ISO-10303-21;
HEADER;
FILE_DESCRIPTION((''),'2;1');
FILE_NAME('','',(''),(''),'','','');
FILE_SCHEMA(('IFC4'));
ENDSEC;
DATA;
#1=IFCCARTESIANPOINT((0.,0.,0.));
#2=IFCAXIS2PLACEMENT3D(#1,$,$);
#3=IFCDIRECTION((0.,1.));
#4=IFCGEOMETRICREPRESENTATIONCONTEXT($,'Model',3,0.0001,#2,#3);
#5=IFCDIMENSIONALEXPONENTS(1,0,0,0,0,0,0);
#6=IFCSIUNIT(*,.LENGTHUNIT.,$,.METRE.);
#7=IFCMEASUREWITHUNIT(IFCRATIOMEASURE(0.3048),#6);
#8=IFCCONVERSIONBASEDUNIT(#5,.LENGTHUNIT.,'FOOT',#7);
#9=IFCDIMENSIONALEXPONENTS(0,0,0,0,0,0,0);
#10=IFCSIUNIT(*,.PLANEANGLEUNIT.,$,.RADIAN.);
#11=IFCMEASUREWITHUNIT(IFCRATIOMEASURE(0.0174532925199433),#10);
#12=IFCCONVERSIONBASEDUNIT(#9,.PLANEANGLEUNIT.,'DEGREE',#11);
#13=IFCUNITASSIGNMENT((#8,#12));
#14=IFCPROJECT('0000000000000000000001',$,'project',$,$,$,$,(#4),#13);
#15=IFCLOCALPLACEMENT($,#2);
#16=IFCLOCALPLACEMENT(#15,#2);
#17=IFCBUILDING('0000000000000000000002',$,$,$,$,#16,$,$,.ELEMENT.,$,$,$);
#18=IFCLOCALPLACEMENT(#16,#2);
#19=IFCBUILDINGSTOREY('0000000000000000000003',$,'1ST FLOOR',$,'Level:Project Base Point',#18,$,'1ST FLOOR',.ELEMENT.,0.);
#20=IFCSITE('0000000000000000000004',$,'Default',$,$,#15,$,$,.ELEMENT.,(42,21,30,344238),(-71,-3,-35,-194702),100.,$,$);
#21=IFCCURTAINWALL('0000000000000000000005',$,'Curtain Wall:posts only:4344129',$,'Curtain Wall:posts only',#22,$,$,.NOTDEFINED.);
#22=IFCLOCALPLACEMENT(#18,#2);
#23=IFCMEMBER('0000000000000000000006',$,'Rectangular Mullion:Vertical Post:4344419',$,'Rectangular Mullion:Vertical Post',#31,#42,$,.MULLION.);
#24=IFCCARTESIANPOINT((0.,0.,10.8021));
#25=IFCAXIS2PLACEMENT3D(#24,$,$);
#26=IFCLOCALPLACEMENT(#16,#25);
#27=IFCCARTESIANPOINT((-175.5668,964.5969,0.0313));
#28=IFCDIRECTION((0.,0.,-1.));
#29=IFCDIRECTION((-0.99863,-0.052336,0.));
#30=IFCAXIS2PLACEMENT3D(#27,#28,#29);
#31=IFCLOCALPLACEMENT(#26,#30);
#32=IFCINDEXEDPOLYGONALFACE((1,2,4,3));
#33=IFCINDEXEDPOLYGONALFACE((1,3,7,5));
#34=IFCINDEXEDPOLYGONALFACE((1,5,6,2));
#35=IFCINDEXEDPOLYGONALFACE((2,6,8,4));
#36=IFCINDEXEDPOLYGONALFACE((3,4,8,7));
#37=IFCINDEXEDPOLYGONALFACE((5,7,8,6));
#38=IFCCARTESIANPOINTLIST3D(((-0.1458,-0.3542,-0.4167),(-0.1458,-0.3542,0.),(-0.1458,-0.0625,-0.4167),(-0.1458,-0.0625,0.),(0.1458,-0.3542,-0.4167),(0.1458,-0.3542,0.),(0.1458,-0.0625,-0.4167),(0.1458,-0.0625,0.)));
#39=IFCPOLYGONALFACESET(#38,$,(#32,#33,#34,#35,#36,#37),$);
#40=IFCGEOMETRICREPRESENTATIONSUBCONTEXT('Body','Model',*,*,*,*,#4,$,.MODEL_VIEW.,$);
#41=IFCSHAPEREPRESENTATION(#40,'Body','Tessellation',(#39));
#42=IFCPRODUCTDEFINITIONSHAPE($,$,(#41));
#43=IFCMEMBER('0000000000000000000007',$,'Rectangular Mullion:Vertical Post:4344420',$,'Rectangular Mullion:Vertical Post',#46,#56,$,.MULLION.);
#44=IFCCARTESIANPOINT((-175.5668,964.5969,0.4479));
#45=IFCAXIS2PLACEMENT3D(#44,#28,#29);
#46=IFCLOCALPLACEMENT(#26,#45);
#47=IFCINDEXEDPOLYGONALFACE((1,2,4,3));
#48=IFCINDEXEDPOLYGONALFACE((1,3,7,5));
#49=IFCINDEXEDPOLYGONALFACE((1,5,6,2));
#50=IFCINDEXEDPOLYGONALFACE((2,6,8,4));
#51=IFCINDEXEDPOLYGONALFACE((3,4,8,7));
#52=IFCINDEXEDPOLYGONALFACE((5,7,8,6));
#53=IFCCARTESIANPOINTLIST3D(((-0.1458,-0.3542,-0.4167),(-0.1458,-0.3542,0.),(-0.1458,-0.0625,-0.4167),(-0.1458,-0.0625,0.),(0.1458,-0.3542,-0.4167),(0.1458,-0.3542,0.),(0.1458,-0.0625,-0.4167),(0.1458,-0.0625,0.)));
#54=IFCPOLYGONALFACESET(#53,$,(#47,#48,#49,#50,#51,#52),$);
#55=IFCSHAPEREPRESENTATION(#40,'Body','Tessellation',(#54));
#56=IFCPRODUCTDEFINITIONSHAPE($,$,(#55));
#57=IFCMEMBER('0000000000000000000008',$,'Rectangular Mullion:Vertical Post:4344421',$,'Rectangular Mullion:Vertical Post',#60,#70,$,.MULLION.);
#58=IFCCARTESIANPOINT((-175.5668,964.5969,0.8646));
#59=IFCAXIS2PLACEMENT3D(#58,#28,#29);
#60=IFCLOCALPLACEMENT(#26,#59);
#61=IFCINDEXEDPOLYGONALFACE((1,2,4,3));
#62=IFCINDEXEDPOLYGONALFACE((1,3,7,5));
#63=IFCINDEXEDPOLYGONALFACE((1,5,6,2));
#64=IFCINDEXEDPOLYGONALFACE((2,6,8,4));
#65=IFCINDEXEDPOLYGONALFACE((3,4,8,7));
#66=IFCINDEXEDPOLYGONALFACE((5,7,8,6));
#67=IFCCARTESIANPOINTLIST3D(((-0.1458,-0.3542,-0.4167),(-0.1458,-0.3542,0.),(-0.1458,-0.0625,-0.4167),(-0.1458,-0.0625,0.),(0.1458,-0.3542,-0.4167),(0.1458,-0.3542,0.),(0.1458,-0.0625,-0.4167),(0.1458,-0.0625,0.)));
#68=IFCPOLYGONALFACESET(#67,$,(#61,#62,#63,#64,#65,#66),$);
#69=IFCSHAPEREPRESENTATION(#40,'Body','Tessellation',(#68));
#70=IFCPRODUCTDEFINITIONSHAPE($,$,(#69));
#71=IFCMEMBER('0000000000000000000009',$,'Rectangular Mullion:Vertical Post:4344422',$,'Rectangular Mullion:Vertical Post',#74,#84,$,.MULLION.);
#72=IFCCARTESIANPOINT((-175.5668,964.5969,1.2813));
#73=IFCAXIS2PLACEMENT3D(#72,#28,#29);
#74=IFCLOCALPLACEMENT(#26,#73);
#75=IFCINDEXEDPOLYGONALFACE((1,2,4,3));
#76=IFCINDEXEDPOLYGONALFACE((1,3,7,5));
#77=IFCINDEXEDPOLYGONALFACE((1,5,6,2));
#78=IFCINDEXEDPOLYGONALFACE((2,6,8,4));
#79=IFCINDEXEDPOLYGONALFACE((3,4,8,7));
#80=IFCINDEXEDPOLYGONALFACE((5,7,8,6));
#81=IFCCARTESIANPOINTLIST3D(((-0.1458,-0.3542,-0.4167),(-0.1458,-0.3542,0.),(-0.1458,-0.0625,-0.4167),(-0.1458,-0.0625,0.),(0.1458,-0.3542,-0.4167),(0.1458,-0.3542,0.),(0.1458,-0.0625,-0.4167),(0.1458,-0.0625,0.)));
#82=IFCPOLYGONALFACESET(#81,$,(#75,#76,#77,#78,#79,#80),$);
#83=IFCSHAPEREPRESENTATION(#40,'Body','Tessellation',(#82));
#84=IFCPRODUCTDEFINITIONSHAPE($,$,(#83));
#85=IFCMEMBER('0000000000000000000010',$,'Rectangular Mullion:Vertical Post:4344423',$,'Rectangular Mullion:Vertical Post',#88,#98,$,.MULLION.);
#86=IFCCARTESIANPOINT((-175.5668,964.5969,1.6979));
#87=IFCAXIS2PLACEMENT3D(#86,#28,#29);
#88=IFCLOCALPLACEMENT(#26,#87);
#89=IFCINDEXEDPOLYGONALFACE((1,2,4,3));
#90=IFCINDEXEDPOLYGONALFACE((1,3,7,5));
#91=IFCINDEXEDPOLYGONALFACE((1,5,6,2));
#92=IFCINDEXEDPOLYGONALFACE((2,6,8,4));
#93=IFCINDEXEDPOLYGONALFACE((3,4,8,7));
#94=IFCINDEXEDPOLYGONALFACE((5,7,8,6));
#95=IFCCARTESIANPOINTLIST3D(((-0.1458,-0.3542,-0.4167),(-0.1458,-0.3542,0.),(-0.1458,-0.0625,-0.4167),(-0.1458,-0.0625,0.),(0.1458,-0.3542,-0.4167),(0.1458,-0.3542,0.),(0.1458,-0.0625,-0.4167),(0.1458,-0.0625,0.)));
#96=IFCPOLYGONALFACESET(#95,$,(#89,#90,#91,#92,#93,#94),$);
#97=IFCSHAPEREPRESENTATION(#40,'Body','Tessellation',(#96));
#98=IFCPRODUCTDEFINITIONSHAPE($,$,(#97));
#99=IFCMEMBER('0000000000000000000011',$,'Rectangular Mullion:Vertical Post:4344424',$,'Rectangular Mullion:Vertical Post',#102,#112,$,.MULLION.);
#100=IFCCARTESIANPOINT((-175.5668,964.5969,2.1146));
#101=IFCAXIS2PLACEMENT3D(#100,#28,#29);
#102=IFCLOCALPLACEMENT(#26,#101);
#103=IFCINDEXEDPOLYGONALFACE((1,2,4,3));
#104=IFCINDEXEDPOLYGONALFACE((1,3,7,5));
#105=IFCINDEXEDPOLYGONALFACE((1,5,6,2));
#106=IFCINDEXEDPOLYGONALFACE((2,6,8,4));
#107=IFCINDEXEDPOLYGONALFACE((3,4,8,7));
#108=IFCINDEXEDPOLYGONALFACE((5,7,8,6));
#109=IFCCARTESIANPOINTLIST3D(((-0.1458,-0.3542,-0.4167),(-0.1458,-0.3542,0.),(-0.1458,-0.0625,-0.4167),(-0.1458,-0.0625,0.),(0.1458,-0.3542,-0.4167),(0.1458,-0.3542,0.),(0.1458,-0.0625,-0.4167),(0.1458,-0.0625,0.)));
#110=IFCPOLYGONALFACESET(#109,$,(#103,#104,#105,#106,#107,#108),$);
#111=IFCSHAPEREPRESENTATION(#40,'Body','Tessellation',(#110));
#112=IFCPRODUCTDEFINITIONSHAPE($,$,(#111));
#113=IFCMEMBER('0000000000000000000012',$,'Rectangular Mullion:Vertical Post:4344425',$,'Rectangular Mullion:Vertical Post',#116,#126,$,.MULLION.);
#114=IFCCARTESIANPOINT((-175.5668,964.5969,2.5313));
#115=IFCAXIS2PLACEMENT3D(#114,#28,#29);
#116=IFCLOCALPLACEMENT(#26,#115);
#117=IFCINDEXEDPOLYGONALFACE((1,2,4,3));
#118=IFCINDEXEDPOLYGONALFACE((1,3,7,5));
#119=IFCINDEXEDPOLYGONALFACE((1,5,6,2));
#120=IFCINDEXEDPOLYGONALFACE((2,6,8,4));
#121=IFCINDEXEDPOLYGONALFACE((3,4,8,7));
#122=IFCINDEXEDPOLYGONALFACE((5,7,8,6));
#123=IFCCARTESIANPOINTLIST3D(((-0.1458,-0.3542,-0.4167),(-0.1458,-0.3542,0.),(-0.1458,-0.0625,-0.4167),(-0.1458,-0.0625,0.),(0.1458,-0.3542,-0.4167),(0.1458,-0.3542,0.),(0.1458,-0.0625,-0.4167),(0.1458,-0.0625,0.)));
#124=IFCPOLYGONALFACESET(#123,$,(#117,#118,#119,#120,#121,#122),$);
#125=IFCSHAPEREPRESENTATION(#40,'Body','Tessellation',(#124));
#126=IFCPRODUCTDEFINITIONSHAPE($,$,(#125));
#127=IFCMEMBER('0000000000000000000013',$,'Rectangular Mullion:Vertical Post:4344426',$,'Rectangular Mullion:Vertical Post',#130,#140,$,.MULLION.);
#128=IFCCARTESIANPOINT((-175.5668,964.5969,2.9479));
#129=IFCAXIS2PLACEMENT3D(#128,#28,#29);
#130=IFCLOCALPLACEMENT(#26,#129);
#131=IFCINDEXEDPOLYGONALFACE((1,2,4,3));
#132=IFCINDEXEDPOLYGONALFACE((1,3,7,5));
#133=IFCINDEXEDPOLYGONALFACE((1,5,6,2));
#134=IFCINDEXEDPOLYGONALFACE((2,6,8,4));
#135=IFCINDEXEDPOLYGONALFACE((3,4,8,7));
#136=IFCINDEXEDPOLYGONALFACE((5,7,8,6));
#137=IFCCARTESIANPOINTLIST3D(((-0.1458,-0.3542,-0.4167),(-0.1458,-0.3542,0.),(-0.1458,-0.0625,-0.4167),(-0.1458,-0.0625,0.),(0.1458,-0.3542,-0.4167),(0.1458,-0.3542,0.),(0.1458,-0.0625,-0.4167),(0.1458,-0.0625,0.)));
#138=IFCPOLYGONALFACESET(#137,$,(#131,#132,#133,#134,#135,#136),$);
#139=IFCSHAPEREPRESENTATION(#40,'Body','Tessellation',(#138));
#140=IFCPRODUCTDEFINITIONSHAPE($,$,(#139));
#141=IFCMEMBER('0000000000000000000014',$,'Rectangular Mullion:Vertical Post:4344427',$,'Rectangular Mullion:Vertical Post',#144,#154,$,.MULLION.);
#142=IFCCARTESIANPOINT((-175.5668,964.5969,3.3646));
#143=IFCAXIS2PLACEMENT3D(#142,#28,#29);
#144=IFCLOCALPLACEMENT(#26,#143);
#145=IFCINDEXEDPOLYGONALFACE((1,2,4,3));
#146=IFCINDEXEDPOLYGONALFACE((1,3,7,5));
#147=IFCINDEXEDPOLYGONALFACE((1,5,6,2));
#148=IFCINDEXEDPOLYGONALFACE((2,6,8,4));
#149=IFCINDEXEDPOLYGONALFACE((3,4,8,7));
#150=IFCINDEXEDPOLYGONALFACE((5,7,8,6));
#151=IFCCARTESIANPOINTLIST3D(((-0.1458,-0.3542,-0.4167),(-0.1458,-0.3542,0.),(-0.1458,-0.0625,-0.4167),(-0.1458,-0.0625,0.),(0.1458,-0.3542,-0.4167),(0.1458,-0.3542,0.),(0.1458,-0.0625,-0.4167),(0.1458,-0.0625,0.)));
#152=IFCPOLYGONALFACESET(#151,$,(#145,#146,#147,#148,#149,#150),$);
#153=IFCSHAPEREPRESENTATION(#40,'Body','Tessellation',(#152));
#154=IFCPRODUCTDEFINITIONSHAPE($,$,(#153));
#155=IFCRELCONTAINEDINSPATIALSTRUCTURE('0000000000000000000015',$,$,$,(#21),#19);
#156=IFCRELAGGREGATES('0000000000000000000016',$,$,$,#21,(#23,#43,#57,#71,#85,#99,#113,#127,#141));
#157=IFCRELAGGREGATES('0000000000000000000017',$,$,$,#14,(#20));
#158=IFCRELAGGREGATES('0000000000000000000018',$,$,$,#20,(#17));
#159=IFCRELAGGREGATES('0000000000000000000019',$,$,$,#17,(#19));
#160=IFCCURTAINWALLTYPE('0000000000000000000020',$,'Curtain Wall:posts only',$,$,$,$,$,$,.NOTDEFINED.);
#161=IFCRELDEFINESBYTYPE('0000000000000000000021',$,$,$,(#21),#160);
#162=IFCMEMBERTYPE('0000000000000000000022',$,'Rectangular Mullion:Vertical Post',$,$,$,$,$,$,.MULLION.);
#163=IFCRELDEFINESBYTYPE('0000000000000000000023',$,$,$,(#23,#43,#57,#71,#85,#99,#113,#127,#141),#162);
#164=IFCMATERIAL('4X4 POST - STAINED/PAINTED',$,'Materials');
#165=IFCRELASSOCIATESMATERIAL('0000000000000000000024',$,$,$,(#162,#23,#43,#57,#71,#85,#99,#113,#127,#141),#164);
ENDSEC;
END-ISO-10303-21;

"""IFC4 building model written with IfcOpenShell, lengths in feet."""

from ifc_helpers import new_model, entity, si_unit, converted_unit, direction, frame, origin, origin_2d_with_axis, place, context, subcontext, project, spatial, rectangle, extrude, source, transform, mapped, material, material_profile, profile_set, profile_usage, type_object, type_shapes, element, aggregate, save


model = new_model("IFC4")

# Units and contexts
model_context = context("Model", 3, precision=0.0001, world=origin(), true_north=direction((0.0, 1.0)))
body_context = subcontext(model_context, "Body", "Model", "MODEL_VIEW")
ifc_project = project(units=[converted_unit("LENGTHUNIT", "FOOT", entity("IfcRatioMeasure", 0.3048), si_unit("LENGTHUNIT", "METRE"), dimensions=[1, 0, 0, 0, 0, 0, 0]), converted_unit("PLANEANGLEUNIT", "DEGREE", entity("IfcRatioMeasure", 0.0174532925199433), si_unit("PLANEANGLEUNIT", "RADIAN"), dimensions=[0, 0, 0, 0, 0, 0, 0])], contexts=[model_context])

# Site, building, storey
site_placement = place(None, origin())
site = spatial("IfcSite", under=ifc_project, at=site_placement, Name="Default", CompositionType="ELEMENT", RefLatitude=(42, 21, 30, 344238), RefLongitude=(-71, -3, -35, -194702), RefElevation=100.0)
building_placement = place(site_placement, origin())
building = spatial("IfcBuilding", under=site, at=building_placement, CompositionType="ELEMENT")
storey_placement = place(building_placement, origin())
storey = spatial("IfcBuildingStorey", under=building, at=storey_placement, Name="1ST FLOOR", ObjectType="Level:Project Base Point", LongName="1ST FLOOR", CompositionType="ELEMENT", Elevation=0.0)

# Curtain wall, members
curtain_wall_type_1 = type_object("IfcCurtainWallType", Name="Curtain Wall:posts only", PredefinedType="NOTDEFINED")
curtain_wall_1_placement = place(storey_placement, origin())
curtain_wall_1 = element("IfcCurtainWall", 1, at=curtain_wall_1_placement, inside=storey, type_object=curtain_wall_type_1, Name="Curtain Wall:posts only:4344129", ObjectType="Curtain Wall:posts only", PredefinedType="NOTDEFINED")
ifc_material_1 = material(Name="4X4 POST - STAINED/PAINTED", Category="Materials")
ifc_material_profile_1 = material_profile(ifc_material_1, rectangle(XDim=0.2917, YDim=0.2917, at=origin_2d_with_axis()), Name="Vertical Post")
ifc_profile_set_1 = profile_set([ifc_material_profile_1], Name="Vertical Post")
ifc_profile_usage_1 = profile_usage(ifc_profile_set_1)
member_type_1 = type_object("IfcMemberType", Name="Rectangular Mullion:Vertical Post", PredefinedType="MULLION", material=ifc_profile_set_1)
shared_shape_1 = source(origin(), body_context, "Body", "SweptSolid", [
    extrude(rectangle(XDim=0.2917, YDim=0.2917, at=origin_2d_with_axis()), frame((0.0, -0.2083, -0.4167), z_axis=(0.0, 0.0, 1.0), x_axis=(0.0, -1.0, 0.0)), (0.0, 0.0, 1.0), 0.4167),
])
type_shapes(member_type_1, [shared_shape_1])
placement = place(building_placement, frame((0.0, 0.0, 10.8021)))
member_1_placement = place(placement, frame((-175.5668, 964.5969, 0.0313), z_axis=(0.0, 0.0, -1.0), x_axis=(-0.99863, -0.052336, 0.0)))
member_1 = element("IfcMember", 2, at=member_1_placement, type_object=member_type_1, material=ifc_profile_usage_1, Name="Rectangular Mullion:Vertical Post:4344419", ObjectType="Rectangular Mullion:Vertical Post", PredefinedType="MULLION", context=body_context, shape_type="MappedRepresentation", body=[
    mapped(shared_shape_1, transform((0.0, 0.0, 0.0), scale=1.0)),
])
ifc_profile_usage_2 = profile_usage(ifc_profile_set_1)
member_2_placement = place(placement, frame((-175.5668, 964.5969, 0.4479), z_axis=(0.0, 0.0, -1.0), x_axis=(-0.99863, -0.052336, 0.0)))
member_2 = element("IfcMember", 3, at=member_2_placement, type_object=member_type_1, material=ifc_profile_usage_2, Name="Rectangular Mullion:Vertical Post:4344420", ObjectType="Rectangular Mullion:Vertical Post", PredefinedType="MULLION", context=body_context, shape_type="MappedRepresentation", body=[
    mapped(shared_shape_1, transform((0.0, 0.0, 0.0), scale=1.0)),
])
ifc_profile_usage_3 = profile_usage(ifc_profile_set_1)
member_3_placement = place(placement, frame((-175.5668, 964.5969, 0.8646), z_axis=(0.0, 0.0, -1.0), x_axis=(-0.99863, -0.052336, 0.0)))
member_3 = element("IfcMember", 4, at=member_3_placement, type_object=member_type_1, material=ifc_profile_usage_3, Name="Rectangular Mullion:Vertical Post:4344421", ObjectType="Rectangular Mullion:Vertical Post", PredefinedType="MULLION", context=body_context, shape_type="MappedRepresentation", body=[
    mapped(shared_shape_1, transform((0.0, 0.0, 0.0), scale=1.0)),
])
ifc_profile_usage_4 = profile_usage(ifc_profile_set_1)
member_4_placement = place(placement, frame((-175.5668, 964.5969, 1.2813), z_axis=(0.0, 0.0, -1.0), x_axis=(-0.99863, -0.052336, 0.0)))
member_4 = element("IfcMember", 5, at=member_4_placement, type_object=member_type_1, material=ifc_profile_usage_4, Name="Rectangular Mullion:Vertical Post:4344422", ObjectType="Rectangular Mullion:Vertical Post", PredefinedType="MULLION", context=body_context, shape_type="MappedRepresentation", body=[
    mapped(shared_shape_1, transform((0.0, 0.0, 0.0), scale=1.0)),
])
ifc_profile_usage_5 = profile_usage(ifc_profile_set_1)
member_5_placement = place(placement, frame((-175.5668, 964.5969, 1.6979), z_axis=(0.0, 0.0, -1.0), x_axis=(-0.99863, -0.052336, 0.0)))
member_5 = element("IfcMember", 6, at=member_5_placement, type_object=member_type_1, material=ifc_profile_usage_5, Name="Rectangular Mullion:Vertical Post:4344423", ObjectType="Rectangular Mullion:Vertical Post", PredefinedType="MULLION", context=body_context, shape_type="MappedRepresentation", body=[
    mapped(shared_shape_1, transform((0.0, 0.0, 0.0), scale=1.0)),
])
ifc_profile_usage_6 = profile_usage(ifc_profile_set_1)
member_6_placement = place(placement, frame((-175.5668, 964.5969, 2.1146), z_axis=(0.0, 0.0, -1.0), x_axis=(-0.99863, -0.052336, 0.0)))
member_6 = element("IfcMember", 7, at=member_6_placement, type_object=member_type_1, material=ifc_profile_usage_6, Name="Rectangular Mullion:Vertical Post:4344424", ObjectType="Rectangular Mullion:Vertical Post", PredefinedType="MULLION", context=body_context, shape_type="MappedRepresentation", body=[
    mapped(shared_shape_1, transform((0.0, 0.0, 0.0), scale=1.0)),
])
ifc_profile_usage_7 = profile_usage(ifc_profile_set_1)
member_7_placement = place(placement, frame((-175.5668, 964.5969, 2.5313), z_axis=(0.0, 0.0, -1.0), x_axis=(-0.99863, -0.052336, 0.0)))
member_7 = element("IfcMember", 8, at=member_7_placement, type_object=member_type_1, material=ifc_profile_usage_7, Name="Rectangular Mullion:Vertical Post:4344425", ObjectType="Rectangular Mullion:Vertical Post", PredefinedType="MULLION", context=body_context, shape_type="MappedRepresentation", body=[
    mapped(shared_shape_1, transform((0.0, 0.0, 0.0), scale=1.0)),
])
ifc_profile_usage_8 = profile_usage(ifc_profile_set_1)
member_8_placement = place(placement, frame((-175.5668, 964.5969, 2.9479), z_axis=(0.0, 0.0, -1.0), x_axis=(-0.99863, -0.052336, 0.0)))
member_8 = element("IfcMember", 9, at=member_8_placement, type_object=member_type_1, material=ifc_profile_usage_8, Name="Rectangular Mullion:Vertical Post:4344426", ObjectType="Rectangular Mullion:Vertical Post", PredefinedType="MULLION", context=body_context, shape_type="MappedRepresentation", body=[
    mapped(shared_shape_1, transform((0.0, 0.0, 0.0), scale=1.0)),
])
ifc_profile_usage_9 = profile_usage(ifc_profile_set_1)
member_9_placement = place(placement, frame((-175.5668, 964.5969, 3.3646), z_axis=(0.0, 0.0, -1.0), x_axis=(-0.99863, -0.052336, 0.0)))
member_9 = element("IfcMember", 10, at=member_9_placement, type_object=member_type_1, material=ifc_profile_usage_9, Name="Rectangular Mullion:Vertical Post:4344427", ObjectType="Rectangular Mullion:Vertical Post", PredefinedType="MULLION", context=body_context, shape_type="MappedRepresentation", body=[
    mapped(shared_shape_1, transform((0.0, 0.0, 0.0), scale=1.0)),
])
aggregate(curtain_wall_1, [member_1, member_2, member_3, member_4, member_5, member_6, member_7, member_8, member_9])

save(model, "model.ifc")
